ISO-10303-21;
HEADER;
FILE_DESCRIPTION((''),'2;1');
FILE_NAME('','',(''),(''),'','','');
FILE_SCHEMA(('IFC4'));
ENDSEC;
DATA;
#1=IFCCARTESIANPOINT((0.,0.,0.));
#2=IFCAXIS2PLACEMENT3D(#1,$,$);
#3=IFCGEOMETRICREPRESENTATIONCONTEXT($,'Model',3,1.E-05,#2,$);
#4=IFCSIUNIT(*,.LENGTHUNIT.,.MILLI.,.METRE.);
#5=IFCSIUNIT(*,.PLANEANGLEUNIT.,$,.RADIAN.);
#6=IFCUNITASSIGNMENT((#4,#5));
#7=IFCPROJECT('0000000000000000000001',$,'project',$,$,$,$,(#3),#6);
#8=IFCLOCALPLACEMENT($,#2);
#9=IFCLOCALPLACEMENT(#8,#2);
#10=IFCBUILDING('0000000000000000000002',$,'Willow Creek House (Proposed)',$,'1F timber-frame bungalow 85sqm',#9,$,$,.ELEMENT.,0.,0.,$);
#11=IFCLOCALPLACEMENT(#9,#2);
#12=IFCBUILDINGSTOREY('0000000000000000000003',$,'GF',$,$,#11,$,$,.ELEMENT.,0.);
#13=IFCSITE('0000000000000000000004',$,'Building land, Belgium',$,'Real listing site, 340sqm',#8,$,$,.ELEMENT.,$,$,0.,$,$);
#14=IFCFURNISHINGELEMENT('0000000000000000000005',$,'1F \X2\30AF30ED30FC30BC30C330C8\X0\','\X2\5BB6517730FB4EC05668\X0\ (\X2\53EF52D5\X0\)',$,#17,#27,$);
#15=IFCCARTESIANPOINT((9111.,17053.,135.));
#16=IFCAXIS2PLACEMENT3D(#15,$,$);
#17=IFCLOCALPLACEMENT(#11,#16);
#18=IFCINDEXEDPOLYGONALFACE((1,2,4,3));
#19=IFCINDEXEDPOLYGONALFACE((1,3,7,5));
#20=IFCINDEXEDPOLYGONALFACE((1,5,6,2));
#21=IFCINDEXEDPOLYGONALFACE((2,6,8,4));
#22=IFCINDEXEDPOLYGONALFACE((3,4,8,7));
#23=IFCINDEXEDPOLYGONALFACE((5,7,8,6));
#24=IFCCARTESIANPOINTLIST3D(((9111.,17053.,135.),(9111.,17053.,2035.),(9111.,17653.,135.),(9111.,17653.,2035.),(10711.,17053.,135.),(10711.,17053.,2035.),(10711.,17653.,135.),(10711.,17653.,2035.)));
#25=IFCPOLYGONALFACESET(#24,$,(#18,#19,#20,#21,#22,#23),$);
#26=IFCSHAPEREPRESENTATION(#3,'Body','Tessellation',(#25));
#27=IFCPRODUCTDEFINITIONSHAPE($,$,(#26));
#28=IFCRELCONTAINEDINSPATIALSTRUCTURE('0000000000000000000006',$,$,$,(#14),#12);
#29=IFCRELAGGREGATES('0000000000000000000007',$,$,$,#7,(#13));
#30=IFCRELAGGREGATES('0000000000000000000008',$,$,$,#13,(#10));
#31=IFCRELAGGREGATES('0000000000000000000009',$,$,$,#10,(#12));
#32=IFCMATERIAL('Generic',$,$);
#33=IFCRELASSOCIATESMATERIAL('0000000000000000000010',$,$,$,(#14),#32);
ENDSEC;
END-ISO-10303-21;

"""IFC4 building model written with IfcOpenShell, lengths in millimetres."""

from ifc_helpers import new_model, si_unit, frame, frame_2d, origin, place, context, project, spatial, rectangle, extrude, material, element, save


model = new_model("IFC4")

# Units and contexts
model_context = context("Model", 3, precision=1e-05, world=origin())
ifc_project = project(units=[si_unit("LENGTHUNIT", "METRE", prefix="MILLI"), si_unit("PLANEANGLEUNIT", "RADIAN")], contexts=[model_context])

# Site, building, storey
site_placement = place(None, origin())
site = spatial("IfcSite", under=ifc_project, at=site_placement, Name="Building land, Belgium", ObjectType="Real listing site, 340sqm", CompositionType="ELEMENT", RefElevation=0.0)
building_placement = place(site_placement, origin())
building = spatial("IfcBuilding", under=site, at=building_placement, Name="Willow Creek House (Proposed)", ObjectType="1F timber-frame bungalow 85sqm", CompositionType="ELEMENT", ElevationOfRefHeight=0.0, ElevationOfTerrain=0.0)
storey_placement = place(building_placement, origin())
storey = spatial("IfcBuildingStorey", under=building, at=storey_placement, Name="GF", CompositionType="ELEMENT", Elevation=0.0)

# Shared definitions
ifc_material_1 = material(Name="Generic")

# Furnishing element
furnishing_placement = place(storey_placement, frame((9111.0, 17053.0, 135.0)))
element("IfcFurnishingElement", 1, at=furnishing_placement, inside=storey, material=ifc_material_1, Name="1F クローゼット", Description="家具・什器 (可動)", context=model_context, shape_type="SweptSolid", body=[
    extrude(rectangle(XDim=1600.0, YDim=600.0, at=frame_2d((800.0, 300.0))), frame((9111.0, 17053.0, 135.0)), (0.0, 0.0, 1.0), 1900.0),
])

save(model, "model.ifc")
